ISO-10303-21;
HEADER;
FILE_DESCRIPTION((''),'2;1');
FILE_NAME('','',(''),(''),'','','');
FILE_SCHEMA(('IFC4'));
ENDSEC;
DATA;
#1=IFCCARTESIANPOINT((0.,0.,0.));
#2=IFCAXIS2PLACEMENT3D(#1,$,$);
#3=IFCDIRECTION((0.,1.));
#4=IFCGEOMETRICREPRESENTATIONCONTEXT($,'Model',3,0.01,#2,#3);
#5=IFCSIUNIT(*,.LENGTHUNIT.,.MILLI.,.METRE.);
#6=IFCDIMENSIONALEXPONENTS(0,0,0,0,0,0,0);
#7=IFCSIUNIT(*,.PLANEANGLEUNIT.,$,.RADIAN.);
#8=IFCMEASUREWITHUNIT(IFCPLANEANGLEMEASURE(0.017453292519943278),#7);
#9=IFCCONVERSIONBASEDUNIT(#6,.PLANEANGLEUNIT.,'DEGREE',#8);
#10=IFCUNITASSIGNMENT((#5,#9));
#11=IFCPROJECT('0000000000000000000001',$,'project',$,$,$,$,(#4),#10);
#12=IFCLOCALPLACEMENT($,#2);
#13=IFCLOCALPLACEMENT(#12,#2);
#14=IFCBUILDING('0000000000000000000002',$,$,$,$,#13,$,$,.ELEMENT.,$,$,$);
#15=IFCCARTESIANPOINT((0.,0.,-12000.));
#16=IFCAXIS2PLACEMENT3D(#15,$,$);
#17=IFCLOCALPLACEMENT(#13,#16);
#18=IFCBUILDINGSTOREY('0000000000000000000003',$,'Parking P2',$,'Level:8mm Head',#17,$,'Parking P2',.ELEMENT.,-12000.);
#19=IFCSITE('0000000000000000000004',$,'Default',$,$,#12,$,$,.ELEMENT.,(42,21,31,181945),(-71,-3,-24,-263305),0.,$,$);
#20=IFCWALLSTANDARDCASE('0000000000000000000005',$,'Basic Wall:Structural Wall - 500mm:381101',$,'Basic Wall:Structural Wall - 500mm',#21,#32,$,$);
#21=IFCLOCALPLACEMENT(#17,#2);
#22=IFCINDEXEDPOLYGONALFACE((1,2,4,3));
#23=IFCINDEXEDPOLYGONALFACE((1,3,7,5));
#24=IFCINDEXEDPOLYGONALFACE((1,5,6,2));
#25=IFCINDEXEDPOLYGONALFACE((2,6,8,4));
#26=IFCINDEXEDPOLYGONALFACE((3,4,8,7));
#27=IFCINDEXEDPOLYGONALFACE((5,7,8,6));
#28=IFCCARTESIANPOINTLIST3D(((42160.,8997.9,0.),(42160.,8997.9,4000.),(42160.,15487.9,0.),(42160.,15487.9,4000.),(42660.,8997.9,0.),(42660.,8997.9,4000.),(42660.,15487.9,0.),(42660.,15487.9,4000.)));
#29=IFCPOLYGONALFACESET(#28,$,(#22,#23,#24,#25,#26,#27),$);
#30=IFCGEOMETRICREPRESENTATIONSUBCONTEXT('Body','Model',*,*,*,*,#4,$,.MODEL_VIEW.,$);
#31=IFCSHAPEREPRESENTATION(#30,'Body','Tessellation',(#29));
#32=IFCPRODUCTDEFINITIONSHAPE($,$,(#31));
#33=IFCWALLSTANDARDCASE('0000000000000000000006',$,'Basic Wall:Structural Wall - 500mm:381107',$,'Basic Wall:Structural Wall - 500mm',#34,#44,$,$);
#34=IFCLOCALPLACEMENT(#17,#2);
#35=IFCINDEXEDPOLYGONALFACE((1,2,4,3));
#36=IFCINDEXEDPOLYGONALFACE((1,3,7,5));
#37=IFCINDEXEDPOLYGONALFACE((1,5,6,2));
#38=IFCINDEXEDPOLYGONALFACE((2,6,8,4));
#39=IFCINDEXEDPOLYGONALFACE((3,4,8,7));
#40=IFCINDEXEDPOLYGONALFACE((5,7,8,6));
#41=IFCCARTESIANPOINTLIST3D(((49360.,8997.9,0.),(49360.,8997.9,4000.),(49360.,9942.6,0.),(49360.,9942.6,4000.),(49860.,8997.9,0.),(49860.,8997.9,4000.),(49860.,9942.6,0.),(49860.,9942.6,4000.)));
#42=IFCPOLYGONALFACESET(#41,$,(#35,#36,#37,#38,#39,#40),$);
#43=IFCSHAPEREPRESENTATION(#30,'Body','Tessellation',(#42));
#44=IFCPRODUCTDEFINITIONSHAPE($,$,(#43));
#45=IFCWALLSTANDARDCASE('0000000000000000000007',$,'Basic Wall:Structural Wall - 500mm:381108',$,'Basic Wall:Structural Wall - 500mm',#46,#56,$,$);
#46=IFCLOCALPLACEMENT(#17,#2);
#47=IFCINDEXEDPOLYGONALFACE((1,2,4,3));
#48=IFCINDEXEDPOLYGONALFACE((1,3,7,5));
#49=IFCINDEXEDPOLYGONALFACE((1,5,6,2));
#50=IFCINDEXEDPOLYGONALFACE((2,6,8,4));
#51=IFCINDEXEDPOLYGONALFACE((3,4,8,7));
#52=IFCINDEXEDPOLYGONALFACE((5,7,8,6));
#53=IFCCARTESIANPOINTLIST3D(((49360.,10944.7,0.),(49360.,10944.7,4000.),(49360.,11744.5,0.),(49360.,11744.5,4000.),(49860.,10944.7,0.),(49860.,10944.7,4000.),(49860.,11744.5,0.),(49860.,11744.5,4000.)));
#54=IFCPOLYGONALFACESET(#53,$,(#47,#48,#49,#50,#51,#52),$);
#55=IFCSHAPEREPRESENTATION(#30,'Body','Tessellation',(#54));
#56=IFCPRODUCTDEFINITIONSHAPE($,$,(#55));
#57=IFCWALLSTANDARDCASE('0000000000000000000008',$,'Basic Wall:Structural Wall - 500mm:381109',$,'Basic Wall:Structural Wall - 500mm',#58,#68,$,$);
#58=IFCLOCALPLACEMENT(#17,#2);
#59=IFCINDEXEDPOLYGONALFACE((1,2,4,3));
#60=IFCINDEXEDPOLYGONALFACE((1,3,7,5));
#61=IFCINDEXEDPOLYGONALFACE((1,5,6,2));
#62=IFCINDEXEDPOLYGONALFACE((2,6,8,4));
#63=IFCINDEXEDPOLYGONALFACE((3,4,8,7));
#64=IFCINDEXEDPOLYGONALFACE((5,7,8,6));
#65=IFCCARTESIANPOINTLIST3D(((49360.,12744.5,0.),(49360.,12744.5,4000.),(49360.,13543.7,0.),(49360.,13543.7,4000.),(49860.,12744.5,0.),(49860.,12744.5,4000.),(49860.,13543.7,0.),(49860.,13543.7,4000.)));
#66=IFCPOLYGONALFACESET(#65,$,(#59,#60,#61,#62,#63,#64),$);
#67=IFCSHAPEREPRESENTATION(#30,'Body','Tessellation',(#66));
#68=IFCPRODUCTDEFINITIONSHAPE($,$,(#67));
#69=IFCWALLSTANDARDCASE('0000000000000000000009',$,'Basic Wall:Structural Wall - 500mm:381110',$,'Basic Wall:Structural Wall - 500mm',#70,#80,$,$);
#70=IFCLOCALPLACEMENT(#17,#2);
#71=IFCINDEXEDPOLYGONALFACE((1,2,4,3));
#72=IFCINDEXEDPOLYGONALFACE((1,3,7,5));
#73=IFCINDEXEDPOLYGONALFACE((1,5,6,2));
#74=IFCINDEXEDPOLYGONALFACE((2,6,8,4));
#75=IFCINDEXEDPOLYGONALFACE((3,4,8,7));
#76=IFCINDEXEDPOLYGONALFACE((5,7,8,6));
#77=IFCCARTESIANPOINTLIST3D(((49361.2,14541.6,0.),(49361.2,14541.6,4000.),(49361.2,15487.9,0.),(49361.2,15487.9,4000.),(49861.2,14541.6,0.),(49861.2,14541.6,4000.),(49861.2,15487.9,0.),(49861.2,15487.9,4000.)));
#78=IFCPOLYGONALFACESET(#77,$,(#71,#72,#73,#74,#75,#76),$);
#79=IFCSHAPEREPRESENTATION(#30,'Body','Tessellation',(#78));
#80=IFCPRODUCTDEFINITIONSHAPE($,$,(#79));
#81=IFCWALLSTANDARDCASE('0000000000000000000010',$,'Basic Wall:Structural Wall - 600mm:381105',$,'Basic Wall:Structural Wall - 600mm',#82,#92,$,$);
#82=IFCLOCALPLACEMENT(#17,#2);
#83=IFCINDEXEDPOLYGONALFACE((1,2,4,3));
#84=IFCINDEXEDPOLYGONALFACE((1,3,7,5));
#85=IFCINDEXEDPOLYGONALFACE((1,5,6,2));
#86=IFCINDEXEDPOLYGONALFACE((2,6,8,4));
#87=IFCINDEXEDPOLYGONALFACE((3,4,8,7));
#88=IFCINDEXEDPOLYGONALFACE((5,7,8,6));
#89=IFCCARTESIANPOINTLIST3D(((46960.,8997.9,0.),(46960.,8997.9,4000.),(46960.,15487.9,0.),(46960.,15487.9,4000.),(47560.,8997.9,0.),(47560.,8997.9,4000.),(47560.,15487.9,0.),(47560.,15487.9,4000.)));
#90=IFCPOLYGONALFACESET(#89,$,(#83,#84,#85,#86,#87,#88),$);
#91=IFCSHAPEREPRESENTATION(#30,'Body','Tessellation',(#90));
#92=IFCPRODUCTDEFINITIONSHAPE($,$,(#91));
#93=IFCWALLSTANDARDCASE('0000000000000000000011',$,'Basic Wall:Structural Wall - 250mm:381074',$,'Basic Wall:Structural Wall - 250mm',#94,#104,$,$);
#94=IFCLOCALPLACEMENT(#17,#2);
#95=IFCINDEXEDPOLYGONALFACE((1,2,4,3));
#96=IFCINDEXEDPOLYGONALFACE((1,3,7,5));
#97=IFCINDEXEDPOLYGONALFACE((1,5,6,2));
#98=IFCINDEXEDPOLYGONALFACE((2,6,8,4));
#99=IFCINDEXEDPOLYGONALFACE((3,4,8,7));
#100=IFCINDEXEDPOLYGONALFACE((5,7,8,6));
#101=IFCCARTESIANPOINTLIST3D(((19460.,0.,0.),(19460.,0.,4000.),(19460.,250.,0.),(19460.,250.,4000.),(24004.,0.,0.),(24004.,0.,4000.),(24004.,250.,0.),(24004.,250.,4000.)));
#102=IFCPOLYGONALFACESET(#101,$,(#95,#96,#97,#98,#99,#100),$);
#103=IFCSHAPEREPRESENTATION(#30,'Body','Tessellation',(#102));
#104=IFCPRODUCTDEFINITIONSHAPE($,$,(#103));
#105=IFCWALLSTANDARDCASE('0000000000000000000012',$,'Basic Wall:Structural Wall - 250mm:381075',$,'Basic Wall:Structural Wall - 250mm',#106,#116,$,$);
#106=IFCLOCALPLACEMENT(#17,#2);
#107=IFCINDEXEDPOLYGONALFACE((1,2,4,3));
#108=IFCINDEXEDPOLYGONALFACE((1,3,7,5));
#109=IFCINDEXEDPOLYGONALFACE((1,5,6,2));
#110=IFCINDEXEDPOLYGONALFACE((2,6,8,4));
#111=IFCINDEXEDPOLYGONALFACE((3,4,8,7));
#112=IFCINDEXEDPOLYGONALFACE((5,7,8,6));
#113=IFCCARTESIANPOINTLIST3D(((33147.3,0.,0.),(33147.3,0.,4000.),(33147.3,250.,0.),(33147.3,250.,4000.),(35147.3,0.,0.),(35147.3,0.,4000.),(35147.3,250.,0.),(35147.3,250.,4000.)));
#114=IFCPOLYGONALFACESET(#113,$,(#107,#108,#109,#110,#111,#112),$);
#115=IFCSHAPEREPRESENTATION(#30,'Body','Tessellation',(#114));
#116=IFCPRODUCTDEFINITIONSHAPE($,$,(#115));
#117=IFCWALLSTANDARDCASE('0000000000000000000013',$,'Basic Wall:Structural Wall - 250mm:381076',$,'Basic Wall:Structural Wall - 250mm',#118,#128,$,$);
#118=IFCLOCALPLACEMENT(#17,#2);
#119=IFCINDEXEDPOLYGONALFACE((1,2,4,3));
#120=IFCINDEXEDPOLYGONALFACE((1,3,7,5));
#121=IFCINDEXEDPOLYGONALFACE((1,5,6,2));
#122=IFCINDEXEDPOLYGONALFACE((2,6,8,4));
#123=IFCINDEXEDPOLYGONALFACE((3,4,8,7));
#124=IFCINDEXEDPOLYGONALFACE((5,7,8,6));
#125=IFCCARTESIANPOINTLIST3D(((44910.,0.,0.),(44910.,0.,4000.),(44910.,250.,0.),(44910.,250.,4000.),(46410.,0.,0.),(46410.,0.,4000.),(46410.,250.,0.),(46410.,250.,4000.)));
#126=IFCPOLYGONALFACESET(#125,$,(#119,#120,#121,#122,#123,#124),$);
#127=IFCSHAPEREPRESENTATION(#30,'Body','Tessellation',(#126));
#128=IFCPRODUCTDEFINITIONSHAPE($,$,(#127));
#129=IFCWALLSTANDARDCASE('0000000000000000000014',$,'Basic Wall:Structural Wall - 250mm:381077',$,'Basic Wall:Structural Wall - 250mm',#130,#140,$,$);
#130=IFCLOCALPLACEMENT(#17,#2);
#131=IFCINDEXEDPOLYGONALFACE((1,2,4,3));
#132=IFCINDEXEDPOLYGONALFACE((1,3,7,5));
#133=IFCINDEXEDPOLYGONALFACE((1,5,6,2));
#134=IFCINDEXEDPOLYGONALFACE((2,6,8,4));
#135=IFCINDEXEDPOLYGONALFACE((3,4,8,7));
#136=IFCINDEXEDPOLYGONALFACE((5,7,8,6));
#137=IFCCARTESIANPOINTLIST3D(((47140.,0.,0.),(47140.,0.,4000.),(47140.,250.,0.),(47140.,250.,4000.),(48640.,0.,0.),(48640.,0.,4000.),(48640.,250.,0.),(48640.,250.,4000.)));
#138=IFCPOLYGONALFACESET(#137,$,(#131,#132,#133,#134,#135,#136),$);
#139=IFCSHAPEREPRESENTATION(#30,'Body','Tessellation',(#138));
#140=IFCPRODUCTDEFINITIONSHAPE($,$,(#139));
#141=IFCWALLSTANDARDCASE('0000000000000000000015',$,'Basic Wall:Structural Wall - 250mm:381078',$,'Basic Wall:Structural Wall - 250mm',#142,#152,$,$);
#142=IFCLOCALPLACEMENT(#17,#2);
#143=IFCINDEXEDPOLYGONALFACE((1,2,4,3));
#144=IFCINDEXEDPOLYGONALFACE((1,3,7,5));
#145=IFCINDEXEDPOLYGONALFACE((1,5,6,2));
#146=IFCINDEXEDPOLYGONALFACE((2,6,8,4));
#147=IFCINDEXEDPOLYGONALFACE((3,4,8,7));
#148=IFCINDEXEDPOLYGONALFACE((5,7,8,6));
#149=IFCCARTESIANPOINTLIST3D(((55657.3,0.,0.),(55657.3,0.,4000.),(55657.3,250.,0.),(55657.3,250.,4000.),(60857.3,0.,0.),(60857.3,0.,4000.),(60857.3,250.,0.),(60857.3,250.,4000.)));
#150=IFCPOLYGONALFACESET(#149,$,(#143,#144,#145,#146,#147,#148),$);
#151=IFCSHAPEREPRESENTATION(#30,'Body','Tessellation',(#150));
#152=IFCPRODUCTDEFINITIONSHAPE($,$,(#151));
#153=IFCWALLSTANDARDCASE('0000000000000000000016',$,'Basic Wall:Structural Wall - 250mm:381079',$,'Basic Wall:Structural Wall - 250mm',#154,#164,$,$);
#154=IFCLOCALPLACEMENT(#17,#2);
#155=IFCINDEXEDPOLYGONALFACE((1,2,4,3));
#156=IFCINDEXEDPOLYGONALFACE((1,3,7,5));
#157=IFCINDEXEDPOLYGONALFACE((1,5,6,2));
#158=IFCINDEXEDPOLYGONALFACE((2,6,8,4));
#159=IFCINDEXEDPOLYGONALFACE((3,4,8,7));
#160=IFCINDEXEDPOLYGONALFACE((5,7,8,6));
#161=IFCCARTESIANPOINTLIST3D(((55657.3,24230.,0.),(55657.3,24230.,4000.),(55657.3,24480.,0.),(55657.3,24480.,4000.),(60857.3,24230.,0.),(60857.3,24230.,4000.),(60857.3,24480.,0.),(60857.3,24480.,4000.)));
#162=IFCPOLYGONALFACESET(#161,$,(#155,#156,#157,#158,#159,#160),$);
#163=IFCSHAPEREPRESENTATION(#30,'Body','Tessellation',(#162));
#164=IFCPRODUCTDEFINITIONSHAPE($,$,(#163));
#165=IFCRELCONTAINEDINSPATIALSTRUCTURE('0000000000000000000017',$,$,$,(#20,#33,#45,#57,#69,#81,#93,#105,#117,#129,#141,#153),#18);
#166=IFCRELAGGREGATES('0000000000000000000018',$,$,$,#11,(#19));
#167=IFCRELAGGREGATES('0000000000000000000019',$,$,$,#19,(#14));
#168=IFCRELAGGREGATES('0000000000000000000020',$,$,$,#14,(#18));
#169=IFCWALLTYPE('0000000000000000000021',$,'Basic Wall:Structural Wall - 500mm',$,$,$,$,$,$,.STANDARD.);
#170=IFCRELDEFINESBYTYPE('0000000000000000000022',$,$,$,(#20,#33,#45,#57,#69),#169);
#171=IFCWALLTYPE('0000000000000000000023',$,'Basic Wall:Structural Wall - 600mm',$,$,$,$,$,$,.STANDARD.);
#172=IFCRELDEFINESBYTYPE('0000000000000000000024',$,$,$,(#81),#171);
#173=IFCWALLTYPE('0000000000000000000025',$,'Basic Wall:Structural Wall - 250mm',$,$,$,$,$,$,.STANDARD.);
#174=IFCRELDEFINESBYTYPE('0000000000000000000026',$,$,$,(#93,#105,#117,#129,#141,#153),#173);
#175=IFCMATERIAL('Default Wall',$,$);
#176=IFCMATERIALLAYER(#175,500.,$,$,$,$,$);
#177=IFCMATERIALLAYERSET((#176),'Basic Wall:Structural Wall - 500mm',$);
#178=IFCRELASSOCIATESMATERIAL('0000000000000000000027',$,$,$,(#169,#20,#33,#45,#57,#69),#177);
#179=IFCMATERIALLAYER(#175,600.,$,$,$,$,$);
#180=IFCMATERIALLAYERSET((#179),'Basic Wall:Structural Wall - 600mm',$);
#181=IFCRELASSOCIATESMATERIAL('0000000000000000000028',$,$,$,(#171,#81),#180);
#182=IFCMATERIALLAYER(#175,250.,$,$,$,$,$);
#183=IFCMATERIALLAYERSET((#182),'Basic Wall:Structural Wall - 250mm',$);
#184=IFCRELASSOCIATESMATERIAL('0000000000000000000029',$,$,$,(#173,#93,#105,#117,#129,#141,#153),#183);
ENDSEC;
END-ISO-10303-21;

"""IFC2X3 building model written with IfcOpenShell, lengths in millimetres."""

from ifc_helpers import new_model, entity, si_unit, converted_unit, direction, frame, frame_2d, origin, place, context, subcontext, project, spatial, rectangle, extrude, material, layer, layer_set, layer_usage, type_object, element, save


model = new_model("IFC2X3")

# Units and contexts
model_context = context("Model", 3, precision=0.01, world=origin(), true_north=direction((0.0, 1.0)))
body_context = subcontext(model_context, "Body", "Model", "MODEL_VIEW")
ifc_project = project(units=[si_unit("LENGTHUNIT", "METRE", prefix="MILLI"), converted_unit("PLANEANGLEUNIT", "DEGREE", entity("IfcPlaneAngleMeasure", 0.017453292519943278), si_unit("PLANEANGLEUNIT", "RADIAN"), dimensions=[0, 0, 0, 0, 0, 0, 0])], contexts=[model_context])

# Site, building, storey
site_placement = place(None, origin())
site = spatial("IfcSite", under=ifc_project, at=site_placement, Name="Default", CompositionType="ELEMENT", RefLatitude=(42, 21, 31, 181945), RefLongitude=(-71, -3, -24, -263305), RefElevation=0.0)
building_placement = place(site_placement, origin())
building = spatial("IfcBuilding", under=site, at=building_placement, CompositionType="ELEMENT")
storey_placement = place(building_placement, frame((0.0, 0.0, -12000.0)))
storey = spatial("IfcBuildingStorey", under=building, at=storey_placement, Name="Parking P2", ObjectType="Level:8mm Head", LongName="Parking P2", CompositionType="ELEMENT", Elevation=-12000.0)

# Walls
ifc_material_1 = material(Name="Default Wall")
ifc_layer_1 = layer(ifc_material_1, 500.0)
ifc_layer_set_1 = layer_set([ifc_layer_1], Name="Basic Wall:Structural Wall - 500mm")
wall_type_1 = type_object("IfcWallType", Name="Basic Wall:Structural Wall - 500mm", PredefinedType="STANDARD", material=ifc_layer_set_1)
ifc_layer_usage_1 = layer_usage(ifc_layer_set_1, "AXIS2", "NEGATIVE", 250.0)
wall_1_placement = place(storey_placement, frame((42410.0, 15487.9, 0.0), z_axis=(0.0, 0.0, 1.0), x_axis=(0.0, -1.0, 0.0)))
element("IfcWallStandardCase", 1, at=wall_1_placement, inside=storey, type_object=wall_type_1, material=ifc_layer_usage_1, Name="Basic Wall:Structural Wall - 500mm:381101", ObjectType="Basic Wall:Structural Wall - 500mm", context=body_context, shape_type="SweptSolid", body=[
    extrude(rectangle(XDim=6490.0, YDim=500.0, at=frame_2d((3245.0, 0.0), x_axis=(-1.0, 0.0))), origin(), (0.0, 0.0, 1.0), 4000.0),
])
ifc_layer_usage_2 = layer_usage(ifc_layer_set_1, "AXIS2", "NEGATIVE", 250.0)
wall_2_placement = place(storey_placement, frame((49610.0, 8997.9, 0.0), z_axis=(0.0, 0.0, 1.0), x_axis=(0.0, 1.0, 0.0)))
element("IfcWallStandardCase", 2, at=wall_2_placement, inside=storey, type_object=wall_type_1, material=ifc_layer_usage_2, Name="Basic Wall:Structural Wall - 500mm:381107", ObjectType="Basic Wall:Structural Wall - 500mm", context=body_context, shape_type="SweptSolid", body=[
    extrude(rectangle(XDim=944.7, YDim=500.0, at=frame_2d((472.3, 0.0), x_axis=(-1.0, 0.0))), origin(), (0.0, 0.0, 1.0), 4000.0),
])
ifc_layer_usage_3 = layer_usage(ifc_layer_set_1, "AXIS2", "NEGATIVE", 250.0)
wall_3_placement = place(storey_placement, frame((49610.0, 10944.7, 0.0), z_axis=(0.0, 0.0, 1.0), x_axis=(0.0, 1.0, 0.0)))
element("IfcWallStandardCase", 3, at=wall_3_placement, inside=storey, type_object=wall_type_1, material=ifc_layer_usage_3, Name="Basic Wall:Structural Wall - 500mm:381108", ObjectType="Basic Wall:Structural Wall - 500mm", context=body_context, shape_type="SweptSolid", body=[
    extrude(rectangle(XDim=799.8, YDim=500.0, at=frame_2d((399.9, 0.0), x_axis=(-1.0, 0.0))), origin(), (0.0, 0.0, 1.0), 4000.0),
])
ifc_layer_usage_4 = layer_usage(ifc_layer_set_1, "AXIS2", "NEGATIVE", 250.0)
wall_4_placement = place(storey_placement, frame((49610.0, 12744.5, 0.0), z_axis=(0.0, 0.0, 1.0), x_axis=(0.0, 1.0, 0.0)))
element("IfcWallStandardCase", 4, at=wall_4_placement, inside=storey, type_object=wall_type_1, material=ifc_layer_usage_4, Name="Basic Wall:Structural Wall - 500mm:381109", ObjectType="Basic Wall:Structural Wall - 500mm", context=body_context, shape_type="SweptSolid", body=[
    extrude(rectangle(XDim=799.2, YDim=500.0, at=frame_2d((399.6, 0.0), x_axis=(-1.0, 0.0))), origin(), (0.0, 0.0, 1.0), 4000.0),
])
ifc_layer_usage_5 = layer_usage(ifc_layer_set_1, "AXIS2", "NEGATIVE", 250.0)
wall_5_placement = place(storey_placement, frame((49611.2, 14541.6, 0.0), z_axis=(0.0, 0.0, 1.0), x_axis=(0.0, 1.0, 0.0)))
element("IfcWallStandardCase", 5, at=wall_5_placement, inside=storey, type_object=wall_type_1, material=ifc_layer_usage_5, Name="Basic Wall:Structural Wall - 500mm:381110", ObjectType="Basic Wall:Structural Wall - 500mm", context=body_context, shape_type="SweptSolid", body=[
    extrude(rectangle(XDim=946.3, YDim=500.0, at=frame_2d((473.2, 0.0), x_axis=(-1.0, 0.0))), origin(), (0.0, 0.0, 1.0), 4000.0),
])
ifc_layer_2 = layer(ifc_material_1, 600.0)
ifc_layer_set_2 = layer_set([ifc_layer_2], Name="Basic Wall:Structural Wall - 600mm")
ifc_layer_usage_6 = layer_usage(ifc_layer_set_2, "AXIS2", "NEGATIVE", 300.0)
wall_type_2 = type_object("IfcWallType", Name="Basic Wall:Structural Wall - 600mm", PredefinedType="STANDARD", material=ifc_layer_set_2)
wall_6_placement = place(storey_placement, frame((47260.0, 15487.9, 0.0), z_axis=(0.0, 0.0, 1.0), x_axis=(0.0, -1.0, 0.0)))
element("IfcWallStandardCase", 6, at=wall_6_placement, inside=storey, type_object=wall_type_2, material=ifc_layer_usage_6, Name="Basic Wall:Structural Wall - 600mm:381105", ObjectType="Basic Wall:Structural Wall - 600mm", context=body_context, shape_type="SweptSolid", body=[
    extrude(rectangle(XDim=6490.0, YDim=600.0, at=frame_2d((3245.0, 0.0), x_axis=(-1.0, 0.0))), origin(), (0.0, 0.0, 1.0), 4000.0),
])
ifc_layer_3 = layer(ifc_material_1, 250.0)
ifc_layer_set_3 = layer_set([ifc_layer_3], Name="Basic Wall:Structural Wall - 250mm")
ifc_layer_usage_7 = layer_usage(ifc_layer_set_3, "AXIS2", "NEGATIVE", 125.0)
wall_type_3 = type_object("IfcWallType", Name="Basic Wall:Structural Wall - 250mm", PredefinedType="STANDARD", material=ifc_layer_set_3)
wall_7_placement = place(storey_placement, frame((24004.0, 125.0, 0.0), z_axis=(0.0, 0.0, 1.0), x_axis=(-1.0, 0.0, 0.0)))
element("IfcWallStandardCase", 7, at=wall_7_placement, inside=storey, type_object=wall_type_3, material=ifc_layer_usage_7, Name="Basic Wall:Structural Wall - 250mm:381074", ObjectType="Basic Wall:Structural Wall - 250mm", context=body_context, shape_type="SweptSolid", body=[
    extrude(rectangle(XDim=4544.0, YDim=250.0, at=frame_2d((2272.0, 0.0), x_axis=(-1.0, 0.0))), origin(), (0.0, 0.0, 1.0), 4000.0),
])
ifc_layer_usage_8 = layer_usage(ifc_layer_set_3, "AXIS2", "NEGATIVE", 125.0)
wall_8_placement = place(storey_placement, frame((35147.3, 125.0, 0.0), z_axis=(0.0, 0.0, 1.0), x_axis=(-1.0, 0.0, 0.0)))
element("IfcWallStandardCase", 8, at=wall_8_placement, inside=storey, type_object=wall_type_3, material=ifc_layer_usage_8, Name="Basic Wall:Structural Wall - 250mm:381075", ObjectType="Basic Wall:Structural Wall - 250mm", context=body_context, shape_type="SweptSolid", body=[
    extrude(rectangle(XDim=2000.0, YDim=250.0, at=frame_2d((1000.0, 0.0), x_axis=(-1.0, 0.0))), origin(), (0.0, 0.0, 1.0), 4000.0),
])
ifc_layer_usage_9 = layer_usage(ifc_layer_set_3, "AXIS2", "NEGATIVE", 125.0)
wall_9_placement = place(storey_placement, frame((46410.0, 125.0, 0.0), z_axis=(0.0, 0.0, 1.0), x_axis=(-1.0, 0.0, 0.0)))
element("IfcWallStandardCase", 9, at=wall_9_placement, inside=storey, type_object=wall_type_3, material=ifc_layer_usage_9, Name="Basic Wall:Structural Wall - 250mm:381076", ObjectType="Basic Wall:Structural Wall - 250mm", context=body_context, shape_type="SweptSolid", body=[
    extrude(rectangle(XDim=1500.0, YDim=250.0, at=frame_2d((750.0, 0.0), x_axis=(-1.0, 0.0))), origin(), (0.0, 0.0, 1.0), 4000.0),
])
ifc_layer_usage_10 = layer_usage(ifc_layer_set_3, "AXIS2", "NEGATIVE", 125.0)
wall_10_placement = place(storey_placement, frame((48640.0, 125.0, 0.0), z_axis=(0.0, 0.0, 1.0), x_axis=(-1.0, 0.0, 0.0)))
element("IfcWallStandardCase", 10, at=wall_10_placement, inside=storey, type_object=wall_type_3, material=ifc_layer_usage_10, Name="Basic Wall:Structural Wall - 250mm:381077", ObjectType="Basic Wall:Structural Wall - 250mm", context=body_context, shape_type="SweptSolid", body=[
    extrude(rectangle(XDim=1500.0, YDim=250.0, at=frame_2d((750.0, 0.0), x_axis=(-1.0, 0.0))), origin(), (0.0, 0.0, 1.0), 4000.0),
])
ifc_layer_usage_11 = layer_usage(ifc_layer_set_3, "AXIS2", "NEGATIVE", 125.0)
wall_11_placement = place(storey_placement, frame((60857.3, 125.0, 0.0), z_axis=(0.0, 0.0, 1.0), x_axis=(-1.0, 0.0, 0.0)))
element("IfcWallStandardCase", 11, at=wall_11_placement, inside=storey, type_object=wall_type_3, material=ifc_layer_usage_11, Name="Basic Wall:Structural Wall - 250mm:381078", ObjectType="Basic Wall:Structural Wall - 250mm", context=body_context, shape_type="SweptSolid", body=[
    extrude(rectangle(XDim=5200.0, YDim=250.0, at=frame_2d((2600.0, 0.0), x_axis=(-1.0, 0.0))), origin(), (0.0, 0.0, 1.0), 4000.0),
])
ifc_layer_usage_12 = layer_usage(ifc_layer_set_3, "AXIS2", "NEGATIVE", 125.0)
wall_12_placement = place(storey_placement, frame((55657.3, 24355.0, 0.0)))
element("IfcWallStandardCase", 12, at=wall_12_placement, inside=storey, type_object=wall_type_3, material=ifc_layer_usage_12, Name="Basic Wall:Structural Wall - 250mm:381079", ObjectType="Basic Wall:Structural Wall - 250mm", context=body_context, shape_type="SweptSolid", body=[
    extrude(rectangle(XDim=5200.0, YDim=250.0, at=frame_2d((2600.0, 0.0), x_axis=(-1.0, 0.0))), origin(), (0.0, 0.0, 1.0), 4000.0),
])

save(model, "model.ifc")
